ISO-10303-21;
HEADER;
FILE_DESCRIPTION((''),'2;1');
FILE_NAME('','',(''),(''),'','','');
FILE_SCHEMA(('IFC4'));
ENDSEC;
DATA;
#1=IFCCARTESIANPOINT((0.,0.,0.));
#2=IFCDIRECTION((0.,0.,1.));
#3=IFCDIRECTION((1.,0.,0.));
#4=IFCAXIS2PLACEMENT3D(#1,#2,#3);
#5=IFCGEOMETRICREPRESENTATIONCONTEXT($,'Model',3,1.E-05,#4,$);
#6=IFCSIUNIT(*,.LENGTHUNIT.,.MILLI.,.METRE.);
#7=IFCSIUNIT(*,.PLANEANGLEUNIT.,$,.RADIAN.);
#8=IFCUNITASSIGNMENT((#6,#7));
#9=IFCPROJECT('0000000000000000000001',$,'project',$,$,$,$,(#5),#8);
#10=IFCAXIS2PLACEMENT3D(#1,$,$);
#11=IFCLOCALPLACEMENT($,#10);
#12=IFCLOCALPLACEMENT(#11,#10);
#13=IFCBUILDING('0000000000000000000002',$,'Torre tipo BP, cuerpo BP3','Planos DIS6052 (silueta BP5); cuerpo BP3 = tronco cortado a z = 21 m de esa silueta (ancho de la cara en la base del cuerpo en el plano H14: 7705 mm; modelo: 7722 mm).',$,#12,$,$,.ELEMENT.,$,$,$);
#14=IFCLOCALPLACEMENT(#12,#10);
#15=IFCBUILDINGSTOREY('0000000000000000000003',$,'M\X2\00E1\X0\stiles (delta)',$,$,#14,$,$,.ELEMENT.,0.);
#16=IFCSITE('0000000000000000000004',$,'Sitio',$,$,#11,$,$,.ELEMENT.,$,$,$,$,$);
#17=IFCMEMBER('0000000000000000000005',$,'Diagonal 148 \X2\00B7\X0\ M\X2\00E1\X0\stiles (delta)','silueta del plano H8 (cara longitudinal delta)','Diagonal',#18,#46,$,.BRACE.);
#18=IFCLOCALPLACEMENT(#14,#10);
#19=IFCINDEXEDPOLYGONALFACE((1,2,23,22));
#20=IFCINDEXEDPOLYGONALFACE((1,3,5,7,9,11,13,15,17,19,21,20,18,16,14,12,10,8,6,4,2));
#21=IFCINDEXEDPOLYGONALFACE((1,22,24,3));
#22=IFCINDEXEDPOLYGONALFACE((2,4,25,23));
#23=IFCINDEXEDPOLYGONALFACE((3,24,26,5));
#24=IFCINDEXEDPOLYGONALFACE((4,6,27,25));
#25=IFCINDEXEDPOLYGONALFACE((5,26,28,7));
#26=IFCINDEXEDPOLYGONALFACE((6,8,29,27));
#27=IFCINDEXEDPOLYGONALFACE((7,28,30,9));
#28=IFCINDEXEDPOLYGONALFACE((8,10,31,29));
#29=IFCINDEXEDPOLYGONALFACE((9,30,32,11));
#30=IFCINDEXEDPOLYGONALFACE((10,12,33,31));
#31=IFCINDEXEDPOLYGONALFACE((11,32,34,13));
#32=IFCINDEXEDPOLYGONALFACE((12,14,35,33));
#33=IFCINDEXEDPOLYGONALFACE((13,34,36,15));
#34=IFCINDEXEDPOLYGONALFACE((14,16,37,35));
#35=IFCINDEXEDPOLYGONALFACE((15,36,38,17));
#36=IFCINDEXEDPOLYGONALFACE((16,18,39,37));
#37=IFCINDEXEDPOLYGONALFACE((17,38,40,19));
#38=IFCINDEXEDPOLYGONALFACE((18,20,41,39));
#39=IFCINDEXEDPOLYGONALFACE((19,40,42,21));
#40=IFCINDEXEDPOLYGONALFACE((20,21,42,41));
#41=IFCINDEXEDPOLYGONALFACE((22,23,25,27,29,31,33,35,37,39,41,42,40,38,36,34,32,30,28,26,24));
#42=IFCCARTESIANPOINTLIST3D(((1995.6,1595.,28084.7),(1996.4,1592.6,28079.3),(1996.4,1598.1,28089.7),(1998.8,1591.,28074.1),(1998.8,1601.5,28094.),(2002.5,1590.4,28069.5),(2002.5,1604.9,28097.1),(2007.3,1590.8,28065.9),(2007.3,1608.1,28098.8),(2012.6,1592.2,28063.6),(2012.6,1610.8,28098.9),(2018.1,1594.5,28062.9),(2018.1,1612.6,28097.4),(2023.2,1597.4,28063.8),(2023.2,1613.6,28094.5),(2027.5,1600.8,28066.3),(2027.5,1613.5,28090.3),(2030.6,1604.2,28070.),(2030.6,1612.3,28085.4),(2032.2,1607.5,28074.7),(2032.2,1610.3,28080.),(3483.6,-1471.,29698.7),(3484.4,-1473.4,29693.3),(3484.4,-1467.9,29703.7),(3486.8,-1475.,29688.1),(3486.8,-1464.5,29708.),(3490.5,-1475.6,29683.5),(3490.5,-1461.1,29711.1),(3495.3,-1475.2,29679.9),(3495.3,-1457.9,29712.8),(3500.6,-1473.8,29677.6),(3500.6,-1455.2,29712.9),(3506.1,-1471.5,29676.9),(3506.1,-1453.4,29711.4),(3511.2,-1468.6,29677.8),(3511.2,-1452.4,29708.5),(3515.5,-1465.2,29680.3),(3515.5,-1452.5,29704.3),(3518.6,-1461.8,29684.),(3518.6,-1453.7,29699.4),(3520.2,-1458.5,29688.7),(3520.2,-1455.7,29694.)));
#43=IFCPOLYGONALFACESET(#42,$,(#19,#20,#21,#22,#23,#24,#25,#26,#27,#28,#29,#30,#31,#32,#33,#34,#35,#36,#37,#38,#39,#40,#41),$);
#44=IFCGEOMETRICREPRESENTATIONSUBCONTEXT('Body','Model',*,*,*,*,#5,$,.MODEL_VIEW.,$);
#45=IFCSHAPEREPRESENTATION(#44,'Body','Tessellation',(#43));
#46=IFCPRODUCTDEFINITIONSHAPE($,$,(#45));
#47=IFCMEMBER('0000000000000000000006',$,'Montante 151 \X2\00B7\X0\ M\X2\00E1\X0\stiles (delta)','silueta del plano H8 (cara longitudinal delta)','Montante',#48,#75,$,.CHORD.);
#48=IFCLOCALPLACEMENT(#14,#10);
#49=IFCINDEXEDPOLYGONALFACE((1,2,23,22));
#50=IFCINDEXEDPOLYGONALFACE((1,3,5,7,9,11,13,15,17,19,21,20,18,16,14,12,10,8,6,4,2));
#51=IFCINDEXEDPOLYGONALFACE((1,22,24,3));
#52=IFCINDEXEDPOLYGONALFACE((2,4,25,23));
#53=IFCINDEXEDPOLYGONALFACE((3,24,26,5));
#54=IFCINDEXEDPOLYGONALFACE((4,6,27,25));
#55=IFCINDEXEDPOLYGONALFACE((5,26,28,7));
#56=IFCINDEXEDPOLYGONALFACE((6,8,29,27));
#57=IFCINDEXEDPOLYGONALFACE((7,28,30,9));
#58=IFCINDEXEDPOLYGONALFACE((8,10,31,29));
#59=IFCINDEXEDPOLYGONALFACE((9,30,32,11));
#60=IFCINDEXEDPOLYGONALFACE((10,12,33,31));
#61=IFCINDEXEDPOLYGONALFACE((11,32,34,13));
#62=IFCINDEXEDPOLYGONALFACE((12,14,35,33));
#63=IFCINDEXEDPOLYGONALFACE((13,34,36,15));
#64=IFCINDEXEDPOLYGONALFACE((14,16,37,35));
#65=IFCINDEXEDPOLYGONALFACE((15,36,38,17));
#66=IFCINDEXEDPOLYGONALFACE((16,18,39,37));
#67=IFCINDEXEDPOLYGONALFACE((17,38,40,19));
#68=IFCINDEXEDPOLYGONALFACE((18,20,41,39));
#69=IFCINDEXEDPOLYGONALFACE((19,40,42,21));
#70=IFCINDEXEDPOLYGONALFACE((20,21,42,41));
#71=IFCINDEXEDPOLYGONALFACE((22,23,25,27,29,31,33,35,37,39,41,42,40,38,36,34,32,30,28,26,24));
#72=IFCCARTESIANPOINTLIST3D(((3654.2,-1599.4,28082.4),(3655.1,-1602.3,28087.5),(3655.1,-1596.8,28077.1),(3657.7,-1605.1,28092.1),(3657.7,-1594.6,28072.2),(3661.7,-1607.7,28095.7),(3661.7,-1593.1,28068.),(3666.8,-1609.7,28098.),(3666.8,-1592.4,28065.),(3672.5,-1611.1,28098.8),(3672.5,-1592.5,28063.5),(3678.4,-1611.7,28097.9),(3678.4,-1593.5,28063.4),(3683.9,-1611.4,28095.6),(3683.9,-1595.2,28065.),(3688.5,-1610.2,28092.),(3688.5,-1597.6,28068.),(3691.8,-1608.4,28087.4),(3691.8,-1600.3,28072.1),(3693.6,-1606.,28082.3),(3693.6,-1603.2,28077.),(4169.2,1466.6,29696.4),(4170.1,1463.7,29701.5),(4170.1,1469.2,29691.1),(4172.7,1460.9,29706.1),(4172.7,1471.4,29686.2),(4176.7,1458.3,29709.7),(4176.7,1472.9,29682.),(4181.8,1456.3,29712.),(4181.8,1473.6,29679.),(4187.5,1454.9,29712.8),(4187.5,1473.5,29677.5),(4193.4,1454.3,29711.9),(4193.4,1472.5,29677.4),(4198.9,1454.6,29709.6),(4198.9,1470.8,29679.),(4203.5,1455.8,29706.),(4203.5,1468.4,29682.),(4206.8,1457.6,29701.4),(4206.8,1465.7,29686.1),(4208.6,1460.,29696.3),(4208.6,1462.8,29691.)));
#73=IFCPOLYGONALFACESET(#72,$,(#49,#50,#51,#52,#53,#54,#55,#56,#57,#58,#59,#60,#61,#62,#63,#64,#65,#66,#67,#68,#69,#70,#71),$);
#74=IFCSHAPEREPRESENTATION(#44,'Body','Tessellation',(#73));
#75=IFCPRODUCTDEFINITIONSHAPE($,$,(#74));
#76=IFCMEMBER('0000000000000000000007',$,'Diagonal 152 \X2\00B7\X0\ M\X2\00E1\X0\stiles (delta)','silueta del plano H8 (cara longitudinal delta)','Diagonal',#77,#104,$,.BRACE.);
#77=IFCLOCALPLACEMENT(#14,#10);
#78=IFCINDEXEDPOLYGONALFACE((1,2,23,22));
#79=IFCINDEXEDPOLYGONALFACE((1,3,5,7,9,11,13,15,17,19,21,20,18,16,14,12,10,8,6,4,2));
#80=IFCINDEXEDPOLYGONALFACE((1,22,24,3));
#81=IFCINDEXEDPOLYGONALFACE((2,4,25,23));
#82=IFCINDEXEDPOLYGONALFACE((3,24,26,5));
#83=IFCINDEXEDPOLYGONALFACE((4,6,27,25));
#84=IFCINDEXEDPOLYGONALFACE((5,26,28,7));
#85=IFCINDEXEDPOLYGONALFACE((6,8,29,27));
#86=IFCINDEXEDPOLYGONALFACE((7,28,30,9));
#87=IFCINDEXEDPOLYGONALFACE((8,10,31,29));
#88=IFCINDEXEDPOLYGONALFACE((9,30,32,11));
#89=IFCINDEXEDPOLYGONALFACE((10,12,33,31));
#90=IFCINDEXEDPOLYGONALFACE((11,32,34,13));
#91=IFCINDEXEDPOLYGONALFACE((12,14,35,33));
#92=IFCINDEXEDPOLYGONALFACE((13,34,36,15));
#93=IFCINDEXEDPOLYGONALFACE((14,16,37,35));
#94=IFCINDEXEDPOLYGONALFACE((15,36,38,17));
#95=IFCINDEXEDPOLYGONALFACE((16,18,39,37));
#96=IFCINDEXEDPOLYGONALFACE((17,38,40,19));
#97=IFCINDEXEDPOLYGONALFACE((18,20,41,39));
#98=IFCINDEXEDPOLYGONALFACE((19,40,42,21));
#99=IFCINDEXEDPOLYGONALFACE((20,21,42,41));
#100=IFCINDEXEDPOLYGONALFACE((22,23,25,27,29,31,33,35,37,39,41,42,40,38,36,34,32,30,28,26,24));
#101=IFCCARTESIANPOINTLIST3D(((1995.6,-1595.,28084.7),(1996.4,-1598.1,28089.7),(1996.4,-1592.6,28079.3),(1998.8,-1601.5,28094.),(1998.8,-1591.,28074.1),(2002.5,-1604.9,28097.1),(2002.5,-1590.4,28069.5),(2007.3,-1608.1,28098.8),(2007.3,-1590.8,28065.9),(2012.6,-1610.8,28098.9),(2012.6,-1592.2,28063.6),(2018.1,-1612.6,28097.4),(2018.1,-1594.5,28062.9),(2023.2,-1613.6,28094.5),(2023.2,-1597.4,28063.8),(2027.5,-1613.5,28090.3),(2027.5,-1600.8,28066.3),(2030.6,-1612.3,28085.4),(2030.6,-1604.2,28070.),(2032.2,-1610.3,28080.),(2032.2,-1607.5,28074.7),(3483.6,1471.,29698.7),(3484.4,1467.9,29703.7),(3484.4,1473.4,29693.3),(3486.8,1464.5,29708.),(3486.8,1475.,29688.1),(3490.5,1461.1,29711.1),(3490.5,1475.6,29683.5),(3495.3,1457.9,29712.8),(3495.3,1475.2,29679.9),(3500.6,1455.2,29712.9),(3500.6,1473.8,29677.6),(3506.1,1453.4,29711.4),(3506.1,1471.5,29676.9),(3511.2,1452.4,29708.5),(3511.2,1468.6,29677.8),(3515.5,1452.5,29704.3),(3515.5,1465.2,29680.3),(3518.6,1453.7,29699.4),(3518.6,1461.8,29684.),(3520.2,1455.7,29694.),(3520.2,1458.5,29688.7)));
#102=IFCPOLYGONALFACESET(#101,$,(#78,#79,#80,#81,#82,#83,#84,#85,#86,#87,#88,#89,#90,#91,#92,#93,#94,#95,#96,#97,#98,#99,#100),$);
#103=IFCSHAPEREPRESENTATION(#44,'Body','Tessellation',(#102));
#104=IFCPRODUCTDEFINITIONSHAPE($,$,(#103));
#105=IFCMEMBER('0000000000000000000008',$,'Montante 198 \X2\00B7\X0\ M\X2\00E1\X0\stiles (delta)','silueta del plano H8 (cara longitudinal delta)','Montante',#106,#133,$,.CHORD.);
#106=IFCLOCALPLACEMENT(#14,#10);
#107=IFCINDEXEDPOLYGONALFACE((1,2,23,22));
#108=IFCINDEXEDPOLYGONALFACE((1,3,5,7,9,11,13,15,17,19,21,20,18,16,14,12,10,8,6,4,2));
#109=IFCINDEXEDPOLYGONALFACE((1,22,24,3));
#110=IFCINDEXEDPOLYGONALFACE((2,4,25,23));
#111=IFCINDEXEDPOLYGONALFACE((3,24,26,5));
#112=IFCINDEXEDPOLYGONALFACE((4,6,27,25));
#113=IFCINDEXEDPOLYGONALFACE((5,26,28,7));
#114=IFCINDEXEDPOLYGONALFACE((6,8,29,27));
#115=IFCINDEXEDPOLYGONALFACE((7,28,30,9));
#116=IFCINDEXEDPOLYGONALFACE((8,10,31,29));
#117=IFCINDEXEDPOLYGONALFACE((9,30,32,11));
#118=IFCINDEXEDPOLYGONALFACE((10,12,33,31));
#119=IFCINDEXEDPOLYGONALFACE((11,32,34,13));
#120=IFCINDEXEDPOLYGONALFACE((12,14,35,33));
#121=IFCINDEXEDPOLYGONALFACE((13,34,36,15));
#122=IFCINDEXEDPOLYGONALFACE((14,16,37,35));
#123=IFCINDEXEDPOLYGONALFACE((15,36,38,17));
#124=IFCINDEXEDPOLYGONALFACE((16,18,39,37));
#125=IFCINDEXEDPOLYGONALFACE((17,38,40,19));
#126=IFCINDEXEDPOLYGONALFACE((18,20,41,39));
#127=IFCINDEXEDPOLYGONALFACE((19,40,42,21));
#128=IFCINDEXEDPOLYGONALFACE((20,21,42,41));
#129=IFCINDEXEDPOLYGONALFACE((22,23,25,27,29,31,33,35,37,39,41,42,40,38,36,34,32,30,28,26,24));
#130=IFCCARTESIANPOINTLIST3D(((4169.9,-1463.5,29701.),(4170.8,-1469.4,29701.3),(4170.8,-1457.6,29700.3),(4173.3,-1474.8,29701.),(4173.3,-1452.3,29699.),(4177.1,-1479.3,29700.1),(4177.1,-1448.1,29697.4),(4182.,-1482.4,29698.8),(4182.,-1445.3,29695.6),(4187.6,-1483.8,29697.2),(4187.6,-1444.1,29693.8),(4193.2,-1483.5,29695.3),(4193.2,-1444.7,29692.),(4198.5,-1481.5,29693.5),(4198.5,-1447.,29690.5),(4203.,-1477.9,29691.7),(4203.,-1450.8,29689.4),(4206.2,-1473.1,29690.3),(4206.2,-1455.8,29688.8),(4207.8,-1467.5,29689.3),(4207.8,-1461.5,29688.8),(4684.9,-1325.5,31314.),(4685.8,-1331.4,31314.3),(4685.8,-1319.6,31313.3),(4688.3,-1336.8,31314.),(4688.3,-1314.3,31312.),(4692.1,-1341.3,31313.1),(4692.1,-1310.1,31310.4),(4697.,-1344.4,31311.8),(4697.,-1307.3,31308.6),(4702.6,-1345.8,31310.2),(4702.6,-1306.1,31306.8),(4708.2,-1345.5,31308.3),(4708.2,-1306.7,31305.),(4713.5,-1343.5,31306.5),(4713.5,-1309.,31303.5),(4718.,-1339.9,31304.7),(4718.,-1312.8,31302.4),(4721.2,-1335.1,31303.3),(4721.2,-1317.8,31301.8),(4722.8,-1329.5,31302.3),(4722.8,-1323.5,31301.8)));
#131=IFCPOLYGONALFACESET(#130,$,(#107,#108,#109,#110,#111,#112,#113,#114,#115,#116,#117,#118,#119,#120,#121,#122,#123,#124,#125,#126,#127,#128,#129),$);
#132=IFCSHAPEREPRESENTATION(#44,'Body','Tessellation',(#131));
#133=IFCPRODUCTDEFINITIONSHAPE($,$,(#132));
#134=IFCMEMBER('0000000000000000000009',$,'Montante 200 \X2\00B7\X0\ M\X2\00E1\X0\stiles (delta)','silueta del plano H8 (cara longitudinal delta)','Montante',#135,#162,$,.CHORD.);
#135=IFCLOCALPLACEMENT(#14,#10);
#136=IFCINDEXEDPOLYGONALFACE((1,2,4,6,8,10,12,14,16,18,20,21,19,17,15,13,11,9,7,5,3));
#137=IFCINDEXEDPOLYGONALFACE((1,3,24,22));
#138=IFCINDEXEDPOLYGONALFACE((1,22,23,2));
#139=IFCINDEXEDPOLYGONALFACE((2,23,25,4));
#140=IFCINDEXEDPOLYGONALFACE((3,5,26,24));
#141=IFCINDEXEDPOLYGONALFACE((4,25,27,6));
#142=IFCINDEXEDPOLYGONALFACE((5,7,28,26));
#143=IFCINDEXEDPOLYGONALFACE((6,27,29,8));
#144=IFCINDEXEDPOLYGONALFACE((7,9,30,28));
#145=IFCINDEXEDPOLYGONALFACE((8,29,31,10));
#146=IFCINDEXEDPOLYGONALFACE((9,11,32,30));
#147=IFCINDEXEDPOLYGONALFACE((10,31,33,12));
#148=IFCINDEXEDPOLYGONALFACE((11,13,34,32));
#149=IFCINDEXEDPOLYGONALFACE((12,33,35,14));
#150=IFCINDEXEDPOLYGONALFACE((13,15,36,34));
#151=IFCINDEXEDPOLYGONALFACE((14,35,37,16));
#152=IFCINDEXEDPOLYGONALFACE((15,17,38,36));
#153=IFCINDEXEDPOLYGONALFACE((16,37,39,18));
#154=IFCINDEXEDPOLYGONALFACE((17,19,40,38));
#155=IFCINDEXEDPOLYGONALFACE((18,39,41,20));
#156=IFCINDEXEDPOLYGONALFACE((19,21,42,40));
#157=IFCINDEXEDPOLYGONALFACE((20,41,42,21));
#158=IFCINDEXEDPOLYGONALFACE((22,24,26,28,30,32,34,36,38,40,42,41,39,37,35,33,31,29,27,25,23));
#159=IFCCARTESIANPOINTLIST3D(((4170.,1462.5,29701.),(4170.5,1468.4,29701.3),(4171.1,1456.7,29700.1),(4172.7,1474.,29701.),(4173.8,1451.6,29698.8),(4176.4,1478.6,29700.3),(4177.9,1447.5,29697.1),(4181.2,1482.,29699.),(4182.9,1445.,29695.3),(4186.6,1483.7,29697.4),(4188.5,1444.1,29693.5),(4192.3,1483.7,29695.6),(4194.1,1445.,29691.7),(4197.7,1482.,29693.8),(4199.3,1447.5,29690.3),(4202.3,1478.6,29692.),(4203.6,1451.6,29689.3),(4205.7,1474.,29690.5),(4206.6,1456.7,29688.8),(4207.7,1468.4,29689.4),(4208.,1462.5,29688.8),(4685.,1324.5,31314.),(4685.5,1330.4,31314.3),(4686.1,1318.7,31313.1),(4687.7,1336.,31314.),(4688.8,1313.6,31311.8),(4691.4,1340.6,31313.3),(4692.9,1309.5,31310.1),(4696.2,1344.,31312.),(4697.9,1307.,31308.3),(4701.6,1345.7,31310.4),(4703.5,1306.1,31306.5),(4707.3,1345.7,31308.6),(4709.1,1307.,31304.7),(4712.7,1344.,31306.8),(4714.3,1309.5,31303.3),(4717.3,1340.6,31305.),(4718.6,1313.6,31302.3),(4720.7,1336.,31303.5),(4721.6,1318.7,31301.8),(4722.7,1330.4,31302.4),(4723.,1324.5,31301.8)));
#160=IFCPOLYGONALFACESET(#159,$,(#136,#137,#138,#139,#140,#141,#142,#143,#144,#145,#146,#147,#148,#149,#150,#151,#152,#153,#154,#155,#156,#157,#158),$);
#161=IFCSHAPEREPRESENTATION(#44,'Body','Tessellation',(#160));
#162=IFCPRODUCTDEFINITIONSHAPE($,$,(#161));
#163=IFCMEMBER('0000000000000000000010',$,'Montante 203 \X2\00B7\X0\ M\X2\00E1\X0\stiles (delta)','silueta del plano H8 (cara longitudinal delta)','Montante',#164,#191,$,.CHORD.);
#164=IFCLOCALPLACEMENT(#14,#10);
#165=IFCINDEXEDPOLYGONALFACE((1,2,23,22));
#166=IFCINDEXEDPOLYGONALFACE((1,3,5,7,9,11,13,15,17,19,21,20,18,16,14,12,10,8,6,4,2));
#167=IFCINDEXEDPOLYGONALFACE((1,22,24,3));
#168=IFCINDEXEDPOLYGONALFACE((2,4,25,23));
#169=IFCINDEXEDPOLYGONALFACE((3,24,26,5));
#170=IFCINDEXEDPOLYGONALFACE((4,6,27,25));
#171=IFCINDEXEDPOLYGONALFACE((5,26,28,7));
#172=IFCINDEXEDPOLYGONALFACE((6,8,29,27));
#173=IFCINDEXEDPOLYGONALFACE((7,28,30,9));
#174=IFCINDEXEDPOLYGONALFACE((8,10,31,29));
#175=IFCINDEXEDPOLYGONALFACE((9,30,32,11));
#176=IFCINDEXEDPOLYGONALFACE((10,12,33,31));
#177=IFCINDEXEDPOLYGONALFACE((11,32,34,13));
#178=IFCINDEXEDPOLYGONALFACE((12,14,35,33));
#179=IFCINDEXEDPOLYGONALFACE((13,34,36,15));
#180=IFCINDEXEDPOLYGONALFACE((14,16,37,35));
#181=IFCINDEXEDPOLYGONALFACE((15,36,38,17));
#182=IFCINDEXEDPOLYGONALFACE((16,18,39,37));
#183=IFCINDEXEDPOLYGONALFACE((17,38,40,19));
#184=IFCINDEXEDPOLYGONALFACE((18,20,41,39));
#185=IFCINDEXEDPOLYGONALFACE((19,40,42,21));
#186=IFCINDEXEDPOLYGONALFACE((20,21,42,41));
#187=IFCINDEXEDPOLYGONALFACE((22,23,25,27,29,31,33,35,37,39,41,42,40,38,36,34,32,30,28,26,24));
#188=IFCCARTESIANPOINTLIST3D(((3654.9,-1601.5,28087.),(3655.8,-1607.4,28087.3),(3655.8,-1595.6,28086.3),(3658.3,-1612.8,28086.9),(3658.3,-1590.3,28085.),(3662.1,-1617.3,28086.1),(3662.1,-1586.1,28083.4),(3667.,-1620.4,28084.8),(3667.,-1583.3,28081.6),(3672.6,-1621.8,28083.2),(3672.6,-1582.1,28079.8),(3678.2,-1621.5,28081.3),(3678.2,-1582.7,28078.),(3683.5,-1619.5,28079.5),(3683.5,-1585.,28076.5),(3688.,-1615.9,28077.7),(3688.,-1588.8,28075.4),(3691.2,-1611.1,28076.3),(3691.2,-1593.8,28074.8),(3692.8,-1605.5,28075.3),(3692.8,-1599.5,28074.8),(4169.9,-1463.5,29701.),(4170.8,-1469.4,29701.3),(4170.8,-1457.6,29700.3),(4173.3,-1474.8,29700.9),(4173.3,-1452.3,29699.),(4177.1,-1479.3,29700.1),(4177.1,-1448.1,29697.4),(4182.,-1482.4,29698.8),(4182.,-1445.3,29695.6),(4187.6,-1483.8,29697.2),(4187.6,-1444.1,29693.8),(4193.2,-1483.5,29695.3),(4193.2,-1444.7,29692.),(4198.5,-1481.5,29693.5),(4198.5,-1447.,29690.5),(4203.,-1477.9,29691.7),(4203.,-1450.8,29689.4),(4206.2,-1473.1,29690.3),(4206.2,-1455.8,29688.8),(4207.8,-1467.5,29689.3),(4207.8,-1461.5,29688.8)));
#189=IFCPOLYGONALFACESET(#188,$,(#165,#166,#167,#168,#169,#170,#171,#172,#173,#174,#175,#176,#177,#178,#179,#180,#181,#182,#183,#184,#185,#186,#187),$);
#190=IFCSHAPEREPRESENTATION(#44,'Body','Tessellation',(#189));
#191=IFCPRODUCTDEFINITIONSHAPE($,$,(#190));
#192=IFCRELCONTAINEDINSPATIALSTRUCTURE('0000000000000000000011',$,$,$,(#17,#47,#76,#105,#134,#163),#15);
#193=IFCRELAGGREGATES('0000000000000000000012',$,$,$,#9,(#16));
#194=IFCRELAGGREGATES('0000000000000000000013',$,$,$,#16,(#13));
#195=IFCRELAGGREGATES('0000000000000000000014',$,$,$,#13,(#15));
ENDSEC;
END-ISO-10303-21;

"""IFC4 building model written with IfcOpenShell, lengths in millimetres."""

from ifc_helpers import new_model, si_unit, frame, origin, origin_with_axes, place, context, subcontext, project, spatial, circle, extrude, element, save


model = new_model("IFC4")

# Units and contexts
model_context = context("Model", 3, precision=1e-05, world=origin_with_axes())
body_context = subcontext(model_context, "Body", "Model", "MODEL_VIEW")
ifc_project = project(units=[si_unit("LENGTHUNIT", "METRE", prefix="MILLI"), si_unit("PLANEANGLEUNIT", "RADIAN")], contexts=[model_context])

# Site, building, storey
site_placement = place(None, origin())
site = spatial("IfcSite", under=ifc_project, at=site_placement, Name="Sitio", CompositionType="ELEMENT")
building_placement = place(site_placement, origin())
building = spatial("IfcBuilding", under=site, at=building_placement, Name="Torre tipo BP, cuerpo BP3", Description="Planos DIS6052 (silueta BP5); cuerpo BP3 = tronco cortado a z = 21 m de esa silueta (ancho de la cara en la base del cuerpo en el plano H14: 7705 mm; modelo: 7722 mm).", CompositionType="ELEMENT")
storey_placement = place(building_placement, origin())
storey = spatial("IfcBuildingStorey", under=building, at=storey_placement, Name="Mástiles (delta)", CompositionType="ELEMENT", Elevation=0.0)

# Members
member_1_placement = place(storey_placement, frame((3502.0, -1464.0, 29695.0), z_axis=(-0.394603, 0.813074, -0.428017), x_axis=(-0.918852, -0.349177, 0.183813)))
element("IfcMember", 1, at=member_1_placement, inside=storey, Name="Diagonal 148 · Mástiles (delta)", Description="silueta del plano H8 (cara longitudinal delta)", ObjectType="Diagonal", PredefinedType="BRACE", context=body_context, shape_type="SweptSolid", body=[
    extrude(circle(Radius=20.0), None, (0.0, 0.0, 1.0), 3770.9),
])
member_2_placement = place(storey_placement, frame((4189.0, 1464.0, 29695.0), z_axis=(-0.147019, -0.875265, -0.460756), x_axis=(-0.989134, 0.130095, 0.068484)))
element("IfcMember", 2, at=member_2_placement, inside=storey, Name="Montante 151 · Mástiles (delta)", Description="silueta del plano H8 (cara longitudinal delta)", ObjectType="Montante", PredefinedType="CHORD", context=body_context, shape_type="SweptSolid", body=[
    extrude(circle(Radius=20.0), None, (0.0, 0.0, 1.0), 3502.9),
])
member_3_placement = place(storey_placement, frame((3502.0, 1464.0, 29695.0), z_axis=(-0.394603, -0.813074, -0.428017), x_axis=(-0.918852, 0.349177, 0.183813)))
element("IfcMember", 3, at=member_3_placement, inside=storey, Name="Diagonal 152 · Mástiles (delta)", Description="silueta del plano H8 (cara longitudinal delta)", ObjectType="Diagonal", PredefinedType="BRACE", context=body_context, shape_type="SweptSolid", body=[
    extrude(circle(Radius=20.0), None, (0.0, 0.0, 1.0), 3770.9),
])
for number, where, z_axis, x_axis, name in (
    (4, (4704.0, -1326.0, 31308.0), (-0.303149, -0.081232, -0.949475), (-0.952943, 0.025841, 0.302046), "Montante 198 · Mástiles (delta)"),
    (5, (4704.0, 1326.0, 31308.0), (-0.303149, 0.081232, -0.949475), (-0.024707, -0.996695, -0.077384), "Montante 200 · Mástiles (delta)"),
):
    element("IfcMember", number, at=place(storey_placement, frame(where, z_axis=z_axis, x_axis=x_axis)), inside=storey, Name=name, Description="silueta del plano H8 (cara longitudinal delta)", ObjectType="Montante", PredefinedType="CHORD", context=body_context, shape_type="SweptSolid", body=[
        extrude(circle(Radius=20.0), None, (0.0, 0.0, 1.0), 1698.8),
    ])
member_4_placement = place(storey_placement, frame((4189.0, -1464.0, 29695.0), z_axis=(-0.30298, -0.081187, -0.949533), x_axis=(-0.952997, 0.025811, 0.301878)))
element("IfcMember", 6, at=member_4_placement, inside=storey, Name="Montante 203 · Mástiles (delta)", Description="silueta del plano H8 (cara longitudinal delta)", ObjectType="Montante", PredefinedType="CHORD", context=body_context, shape_type="SweptSolid", body=[
    extrude(circle(Radius=20.0), None, (0.0, 0.0, 1.0), 1699.8),
])

save(model, "model.ifc")
